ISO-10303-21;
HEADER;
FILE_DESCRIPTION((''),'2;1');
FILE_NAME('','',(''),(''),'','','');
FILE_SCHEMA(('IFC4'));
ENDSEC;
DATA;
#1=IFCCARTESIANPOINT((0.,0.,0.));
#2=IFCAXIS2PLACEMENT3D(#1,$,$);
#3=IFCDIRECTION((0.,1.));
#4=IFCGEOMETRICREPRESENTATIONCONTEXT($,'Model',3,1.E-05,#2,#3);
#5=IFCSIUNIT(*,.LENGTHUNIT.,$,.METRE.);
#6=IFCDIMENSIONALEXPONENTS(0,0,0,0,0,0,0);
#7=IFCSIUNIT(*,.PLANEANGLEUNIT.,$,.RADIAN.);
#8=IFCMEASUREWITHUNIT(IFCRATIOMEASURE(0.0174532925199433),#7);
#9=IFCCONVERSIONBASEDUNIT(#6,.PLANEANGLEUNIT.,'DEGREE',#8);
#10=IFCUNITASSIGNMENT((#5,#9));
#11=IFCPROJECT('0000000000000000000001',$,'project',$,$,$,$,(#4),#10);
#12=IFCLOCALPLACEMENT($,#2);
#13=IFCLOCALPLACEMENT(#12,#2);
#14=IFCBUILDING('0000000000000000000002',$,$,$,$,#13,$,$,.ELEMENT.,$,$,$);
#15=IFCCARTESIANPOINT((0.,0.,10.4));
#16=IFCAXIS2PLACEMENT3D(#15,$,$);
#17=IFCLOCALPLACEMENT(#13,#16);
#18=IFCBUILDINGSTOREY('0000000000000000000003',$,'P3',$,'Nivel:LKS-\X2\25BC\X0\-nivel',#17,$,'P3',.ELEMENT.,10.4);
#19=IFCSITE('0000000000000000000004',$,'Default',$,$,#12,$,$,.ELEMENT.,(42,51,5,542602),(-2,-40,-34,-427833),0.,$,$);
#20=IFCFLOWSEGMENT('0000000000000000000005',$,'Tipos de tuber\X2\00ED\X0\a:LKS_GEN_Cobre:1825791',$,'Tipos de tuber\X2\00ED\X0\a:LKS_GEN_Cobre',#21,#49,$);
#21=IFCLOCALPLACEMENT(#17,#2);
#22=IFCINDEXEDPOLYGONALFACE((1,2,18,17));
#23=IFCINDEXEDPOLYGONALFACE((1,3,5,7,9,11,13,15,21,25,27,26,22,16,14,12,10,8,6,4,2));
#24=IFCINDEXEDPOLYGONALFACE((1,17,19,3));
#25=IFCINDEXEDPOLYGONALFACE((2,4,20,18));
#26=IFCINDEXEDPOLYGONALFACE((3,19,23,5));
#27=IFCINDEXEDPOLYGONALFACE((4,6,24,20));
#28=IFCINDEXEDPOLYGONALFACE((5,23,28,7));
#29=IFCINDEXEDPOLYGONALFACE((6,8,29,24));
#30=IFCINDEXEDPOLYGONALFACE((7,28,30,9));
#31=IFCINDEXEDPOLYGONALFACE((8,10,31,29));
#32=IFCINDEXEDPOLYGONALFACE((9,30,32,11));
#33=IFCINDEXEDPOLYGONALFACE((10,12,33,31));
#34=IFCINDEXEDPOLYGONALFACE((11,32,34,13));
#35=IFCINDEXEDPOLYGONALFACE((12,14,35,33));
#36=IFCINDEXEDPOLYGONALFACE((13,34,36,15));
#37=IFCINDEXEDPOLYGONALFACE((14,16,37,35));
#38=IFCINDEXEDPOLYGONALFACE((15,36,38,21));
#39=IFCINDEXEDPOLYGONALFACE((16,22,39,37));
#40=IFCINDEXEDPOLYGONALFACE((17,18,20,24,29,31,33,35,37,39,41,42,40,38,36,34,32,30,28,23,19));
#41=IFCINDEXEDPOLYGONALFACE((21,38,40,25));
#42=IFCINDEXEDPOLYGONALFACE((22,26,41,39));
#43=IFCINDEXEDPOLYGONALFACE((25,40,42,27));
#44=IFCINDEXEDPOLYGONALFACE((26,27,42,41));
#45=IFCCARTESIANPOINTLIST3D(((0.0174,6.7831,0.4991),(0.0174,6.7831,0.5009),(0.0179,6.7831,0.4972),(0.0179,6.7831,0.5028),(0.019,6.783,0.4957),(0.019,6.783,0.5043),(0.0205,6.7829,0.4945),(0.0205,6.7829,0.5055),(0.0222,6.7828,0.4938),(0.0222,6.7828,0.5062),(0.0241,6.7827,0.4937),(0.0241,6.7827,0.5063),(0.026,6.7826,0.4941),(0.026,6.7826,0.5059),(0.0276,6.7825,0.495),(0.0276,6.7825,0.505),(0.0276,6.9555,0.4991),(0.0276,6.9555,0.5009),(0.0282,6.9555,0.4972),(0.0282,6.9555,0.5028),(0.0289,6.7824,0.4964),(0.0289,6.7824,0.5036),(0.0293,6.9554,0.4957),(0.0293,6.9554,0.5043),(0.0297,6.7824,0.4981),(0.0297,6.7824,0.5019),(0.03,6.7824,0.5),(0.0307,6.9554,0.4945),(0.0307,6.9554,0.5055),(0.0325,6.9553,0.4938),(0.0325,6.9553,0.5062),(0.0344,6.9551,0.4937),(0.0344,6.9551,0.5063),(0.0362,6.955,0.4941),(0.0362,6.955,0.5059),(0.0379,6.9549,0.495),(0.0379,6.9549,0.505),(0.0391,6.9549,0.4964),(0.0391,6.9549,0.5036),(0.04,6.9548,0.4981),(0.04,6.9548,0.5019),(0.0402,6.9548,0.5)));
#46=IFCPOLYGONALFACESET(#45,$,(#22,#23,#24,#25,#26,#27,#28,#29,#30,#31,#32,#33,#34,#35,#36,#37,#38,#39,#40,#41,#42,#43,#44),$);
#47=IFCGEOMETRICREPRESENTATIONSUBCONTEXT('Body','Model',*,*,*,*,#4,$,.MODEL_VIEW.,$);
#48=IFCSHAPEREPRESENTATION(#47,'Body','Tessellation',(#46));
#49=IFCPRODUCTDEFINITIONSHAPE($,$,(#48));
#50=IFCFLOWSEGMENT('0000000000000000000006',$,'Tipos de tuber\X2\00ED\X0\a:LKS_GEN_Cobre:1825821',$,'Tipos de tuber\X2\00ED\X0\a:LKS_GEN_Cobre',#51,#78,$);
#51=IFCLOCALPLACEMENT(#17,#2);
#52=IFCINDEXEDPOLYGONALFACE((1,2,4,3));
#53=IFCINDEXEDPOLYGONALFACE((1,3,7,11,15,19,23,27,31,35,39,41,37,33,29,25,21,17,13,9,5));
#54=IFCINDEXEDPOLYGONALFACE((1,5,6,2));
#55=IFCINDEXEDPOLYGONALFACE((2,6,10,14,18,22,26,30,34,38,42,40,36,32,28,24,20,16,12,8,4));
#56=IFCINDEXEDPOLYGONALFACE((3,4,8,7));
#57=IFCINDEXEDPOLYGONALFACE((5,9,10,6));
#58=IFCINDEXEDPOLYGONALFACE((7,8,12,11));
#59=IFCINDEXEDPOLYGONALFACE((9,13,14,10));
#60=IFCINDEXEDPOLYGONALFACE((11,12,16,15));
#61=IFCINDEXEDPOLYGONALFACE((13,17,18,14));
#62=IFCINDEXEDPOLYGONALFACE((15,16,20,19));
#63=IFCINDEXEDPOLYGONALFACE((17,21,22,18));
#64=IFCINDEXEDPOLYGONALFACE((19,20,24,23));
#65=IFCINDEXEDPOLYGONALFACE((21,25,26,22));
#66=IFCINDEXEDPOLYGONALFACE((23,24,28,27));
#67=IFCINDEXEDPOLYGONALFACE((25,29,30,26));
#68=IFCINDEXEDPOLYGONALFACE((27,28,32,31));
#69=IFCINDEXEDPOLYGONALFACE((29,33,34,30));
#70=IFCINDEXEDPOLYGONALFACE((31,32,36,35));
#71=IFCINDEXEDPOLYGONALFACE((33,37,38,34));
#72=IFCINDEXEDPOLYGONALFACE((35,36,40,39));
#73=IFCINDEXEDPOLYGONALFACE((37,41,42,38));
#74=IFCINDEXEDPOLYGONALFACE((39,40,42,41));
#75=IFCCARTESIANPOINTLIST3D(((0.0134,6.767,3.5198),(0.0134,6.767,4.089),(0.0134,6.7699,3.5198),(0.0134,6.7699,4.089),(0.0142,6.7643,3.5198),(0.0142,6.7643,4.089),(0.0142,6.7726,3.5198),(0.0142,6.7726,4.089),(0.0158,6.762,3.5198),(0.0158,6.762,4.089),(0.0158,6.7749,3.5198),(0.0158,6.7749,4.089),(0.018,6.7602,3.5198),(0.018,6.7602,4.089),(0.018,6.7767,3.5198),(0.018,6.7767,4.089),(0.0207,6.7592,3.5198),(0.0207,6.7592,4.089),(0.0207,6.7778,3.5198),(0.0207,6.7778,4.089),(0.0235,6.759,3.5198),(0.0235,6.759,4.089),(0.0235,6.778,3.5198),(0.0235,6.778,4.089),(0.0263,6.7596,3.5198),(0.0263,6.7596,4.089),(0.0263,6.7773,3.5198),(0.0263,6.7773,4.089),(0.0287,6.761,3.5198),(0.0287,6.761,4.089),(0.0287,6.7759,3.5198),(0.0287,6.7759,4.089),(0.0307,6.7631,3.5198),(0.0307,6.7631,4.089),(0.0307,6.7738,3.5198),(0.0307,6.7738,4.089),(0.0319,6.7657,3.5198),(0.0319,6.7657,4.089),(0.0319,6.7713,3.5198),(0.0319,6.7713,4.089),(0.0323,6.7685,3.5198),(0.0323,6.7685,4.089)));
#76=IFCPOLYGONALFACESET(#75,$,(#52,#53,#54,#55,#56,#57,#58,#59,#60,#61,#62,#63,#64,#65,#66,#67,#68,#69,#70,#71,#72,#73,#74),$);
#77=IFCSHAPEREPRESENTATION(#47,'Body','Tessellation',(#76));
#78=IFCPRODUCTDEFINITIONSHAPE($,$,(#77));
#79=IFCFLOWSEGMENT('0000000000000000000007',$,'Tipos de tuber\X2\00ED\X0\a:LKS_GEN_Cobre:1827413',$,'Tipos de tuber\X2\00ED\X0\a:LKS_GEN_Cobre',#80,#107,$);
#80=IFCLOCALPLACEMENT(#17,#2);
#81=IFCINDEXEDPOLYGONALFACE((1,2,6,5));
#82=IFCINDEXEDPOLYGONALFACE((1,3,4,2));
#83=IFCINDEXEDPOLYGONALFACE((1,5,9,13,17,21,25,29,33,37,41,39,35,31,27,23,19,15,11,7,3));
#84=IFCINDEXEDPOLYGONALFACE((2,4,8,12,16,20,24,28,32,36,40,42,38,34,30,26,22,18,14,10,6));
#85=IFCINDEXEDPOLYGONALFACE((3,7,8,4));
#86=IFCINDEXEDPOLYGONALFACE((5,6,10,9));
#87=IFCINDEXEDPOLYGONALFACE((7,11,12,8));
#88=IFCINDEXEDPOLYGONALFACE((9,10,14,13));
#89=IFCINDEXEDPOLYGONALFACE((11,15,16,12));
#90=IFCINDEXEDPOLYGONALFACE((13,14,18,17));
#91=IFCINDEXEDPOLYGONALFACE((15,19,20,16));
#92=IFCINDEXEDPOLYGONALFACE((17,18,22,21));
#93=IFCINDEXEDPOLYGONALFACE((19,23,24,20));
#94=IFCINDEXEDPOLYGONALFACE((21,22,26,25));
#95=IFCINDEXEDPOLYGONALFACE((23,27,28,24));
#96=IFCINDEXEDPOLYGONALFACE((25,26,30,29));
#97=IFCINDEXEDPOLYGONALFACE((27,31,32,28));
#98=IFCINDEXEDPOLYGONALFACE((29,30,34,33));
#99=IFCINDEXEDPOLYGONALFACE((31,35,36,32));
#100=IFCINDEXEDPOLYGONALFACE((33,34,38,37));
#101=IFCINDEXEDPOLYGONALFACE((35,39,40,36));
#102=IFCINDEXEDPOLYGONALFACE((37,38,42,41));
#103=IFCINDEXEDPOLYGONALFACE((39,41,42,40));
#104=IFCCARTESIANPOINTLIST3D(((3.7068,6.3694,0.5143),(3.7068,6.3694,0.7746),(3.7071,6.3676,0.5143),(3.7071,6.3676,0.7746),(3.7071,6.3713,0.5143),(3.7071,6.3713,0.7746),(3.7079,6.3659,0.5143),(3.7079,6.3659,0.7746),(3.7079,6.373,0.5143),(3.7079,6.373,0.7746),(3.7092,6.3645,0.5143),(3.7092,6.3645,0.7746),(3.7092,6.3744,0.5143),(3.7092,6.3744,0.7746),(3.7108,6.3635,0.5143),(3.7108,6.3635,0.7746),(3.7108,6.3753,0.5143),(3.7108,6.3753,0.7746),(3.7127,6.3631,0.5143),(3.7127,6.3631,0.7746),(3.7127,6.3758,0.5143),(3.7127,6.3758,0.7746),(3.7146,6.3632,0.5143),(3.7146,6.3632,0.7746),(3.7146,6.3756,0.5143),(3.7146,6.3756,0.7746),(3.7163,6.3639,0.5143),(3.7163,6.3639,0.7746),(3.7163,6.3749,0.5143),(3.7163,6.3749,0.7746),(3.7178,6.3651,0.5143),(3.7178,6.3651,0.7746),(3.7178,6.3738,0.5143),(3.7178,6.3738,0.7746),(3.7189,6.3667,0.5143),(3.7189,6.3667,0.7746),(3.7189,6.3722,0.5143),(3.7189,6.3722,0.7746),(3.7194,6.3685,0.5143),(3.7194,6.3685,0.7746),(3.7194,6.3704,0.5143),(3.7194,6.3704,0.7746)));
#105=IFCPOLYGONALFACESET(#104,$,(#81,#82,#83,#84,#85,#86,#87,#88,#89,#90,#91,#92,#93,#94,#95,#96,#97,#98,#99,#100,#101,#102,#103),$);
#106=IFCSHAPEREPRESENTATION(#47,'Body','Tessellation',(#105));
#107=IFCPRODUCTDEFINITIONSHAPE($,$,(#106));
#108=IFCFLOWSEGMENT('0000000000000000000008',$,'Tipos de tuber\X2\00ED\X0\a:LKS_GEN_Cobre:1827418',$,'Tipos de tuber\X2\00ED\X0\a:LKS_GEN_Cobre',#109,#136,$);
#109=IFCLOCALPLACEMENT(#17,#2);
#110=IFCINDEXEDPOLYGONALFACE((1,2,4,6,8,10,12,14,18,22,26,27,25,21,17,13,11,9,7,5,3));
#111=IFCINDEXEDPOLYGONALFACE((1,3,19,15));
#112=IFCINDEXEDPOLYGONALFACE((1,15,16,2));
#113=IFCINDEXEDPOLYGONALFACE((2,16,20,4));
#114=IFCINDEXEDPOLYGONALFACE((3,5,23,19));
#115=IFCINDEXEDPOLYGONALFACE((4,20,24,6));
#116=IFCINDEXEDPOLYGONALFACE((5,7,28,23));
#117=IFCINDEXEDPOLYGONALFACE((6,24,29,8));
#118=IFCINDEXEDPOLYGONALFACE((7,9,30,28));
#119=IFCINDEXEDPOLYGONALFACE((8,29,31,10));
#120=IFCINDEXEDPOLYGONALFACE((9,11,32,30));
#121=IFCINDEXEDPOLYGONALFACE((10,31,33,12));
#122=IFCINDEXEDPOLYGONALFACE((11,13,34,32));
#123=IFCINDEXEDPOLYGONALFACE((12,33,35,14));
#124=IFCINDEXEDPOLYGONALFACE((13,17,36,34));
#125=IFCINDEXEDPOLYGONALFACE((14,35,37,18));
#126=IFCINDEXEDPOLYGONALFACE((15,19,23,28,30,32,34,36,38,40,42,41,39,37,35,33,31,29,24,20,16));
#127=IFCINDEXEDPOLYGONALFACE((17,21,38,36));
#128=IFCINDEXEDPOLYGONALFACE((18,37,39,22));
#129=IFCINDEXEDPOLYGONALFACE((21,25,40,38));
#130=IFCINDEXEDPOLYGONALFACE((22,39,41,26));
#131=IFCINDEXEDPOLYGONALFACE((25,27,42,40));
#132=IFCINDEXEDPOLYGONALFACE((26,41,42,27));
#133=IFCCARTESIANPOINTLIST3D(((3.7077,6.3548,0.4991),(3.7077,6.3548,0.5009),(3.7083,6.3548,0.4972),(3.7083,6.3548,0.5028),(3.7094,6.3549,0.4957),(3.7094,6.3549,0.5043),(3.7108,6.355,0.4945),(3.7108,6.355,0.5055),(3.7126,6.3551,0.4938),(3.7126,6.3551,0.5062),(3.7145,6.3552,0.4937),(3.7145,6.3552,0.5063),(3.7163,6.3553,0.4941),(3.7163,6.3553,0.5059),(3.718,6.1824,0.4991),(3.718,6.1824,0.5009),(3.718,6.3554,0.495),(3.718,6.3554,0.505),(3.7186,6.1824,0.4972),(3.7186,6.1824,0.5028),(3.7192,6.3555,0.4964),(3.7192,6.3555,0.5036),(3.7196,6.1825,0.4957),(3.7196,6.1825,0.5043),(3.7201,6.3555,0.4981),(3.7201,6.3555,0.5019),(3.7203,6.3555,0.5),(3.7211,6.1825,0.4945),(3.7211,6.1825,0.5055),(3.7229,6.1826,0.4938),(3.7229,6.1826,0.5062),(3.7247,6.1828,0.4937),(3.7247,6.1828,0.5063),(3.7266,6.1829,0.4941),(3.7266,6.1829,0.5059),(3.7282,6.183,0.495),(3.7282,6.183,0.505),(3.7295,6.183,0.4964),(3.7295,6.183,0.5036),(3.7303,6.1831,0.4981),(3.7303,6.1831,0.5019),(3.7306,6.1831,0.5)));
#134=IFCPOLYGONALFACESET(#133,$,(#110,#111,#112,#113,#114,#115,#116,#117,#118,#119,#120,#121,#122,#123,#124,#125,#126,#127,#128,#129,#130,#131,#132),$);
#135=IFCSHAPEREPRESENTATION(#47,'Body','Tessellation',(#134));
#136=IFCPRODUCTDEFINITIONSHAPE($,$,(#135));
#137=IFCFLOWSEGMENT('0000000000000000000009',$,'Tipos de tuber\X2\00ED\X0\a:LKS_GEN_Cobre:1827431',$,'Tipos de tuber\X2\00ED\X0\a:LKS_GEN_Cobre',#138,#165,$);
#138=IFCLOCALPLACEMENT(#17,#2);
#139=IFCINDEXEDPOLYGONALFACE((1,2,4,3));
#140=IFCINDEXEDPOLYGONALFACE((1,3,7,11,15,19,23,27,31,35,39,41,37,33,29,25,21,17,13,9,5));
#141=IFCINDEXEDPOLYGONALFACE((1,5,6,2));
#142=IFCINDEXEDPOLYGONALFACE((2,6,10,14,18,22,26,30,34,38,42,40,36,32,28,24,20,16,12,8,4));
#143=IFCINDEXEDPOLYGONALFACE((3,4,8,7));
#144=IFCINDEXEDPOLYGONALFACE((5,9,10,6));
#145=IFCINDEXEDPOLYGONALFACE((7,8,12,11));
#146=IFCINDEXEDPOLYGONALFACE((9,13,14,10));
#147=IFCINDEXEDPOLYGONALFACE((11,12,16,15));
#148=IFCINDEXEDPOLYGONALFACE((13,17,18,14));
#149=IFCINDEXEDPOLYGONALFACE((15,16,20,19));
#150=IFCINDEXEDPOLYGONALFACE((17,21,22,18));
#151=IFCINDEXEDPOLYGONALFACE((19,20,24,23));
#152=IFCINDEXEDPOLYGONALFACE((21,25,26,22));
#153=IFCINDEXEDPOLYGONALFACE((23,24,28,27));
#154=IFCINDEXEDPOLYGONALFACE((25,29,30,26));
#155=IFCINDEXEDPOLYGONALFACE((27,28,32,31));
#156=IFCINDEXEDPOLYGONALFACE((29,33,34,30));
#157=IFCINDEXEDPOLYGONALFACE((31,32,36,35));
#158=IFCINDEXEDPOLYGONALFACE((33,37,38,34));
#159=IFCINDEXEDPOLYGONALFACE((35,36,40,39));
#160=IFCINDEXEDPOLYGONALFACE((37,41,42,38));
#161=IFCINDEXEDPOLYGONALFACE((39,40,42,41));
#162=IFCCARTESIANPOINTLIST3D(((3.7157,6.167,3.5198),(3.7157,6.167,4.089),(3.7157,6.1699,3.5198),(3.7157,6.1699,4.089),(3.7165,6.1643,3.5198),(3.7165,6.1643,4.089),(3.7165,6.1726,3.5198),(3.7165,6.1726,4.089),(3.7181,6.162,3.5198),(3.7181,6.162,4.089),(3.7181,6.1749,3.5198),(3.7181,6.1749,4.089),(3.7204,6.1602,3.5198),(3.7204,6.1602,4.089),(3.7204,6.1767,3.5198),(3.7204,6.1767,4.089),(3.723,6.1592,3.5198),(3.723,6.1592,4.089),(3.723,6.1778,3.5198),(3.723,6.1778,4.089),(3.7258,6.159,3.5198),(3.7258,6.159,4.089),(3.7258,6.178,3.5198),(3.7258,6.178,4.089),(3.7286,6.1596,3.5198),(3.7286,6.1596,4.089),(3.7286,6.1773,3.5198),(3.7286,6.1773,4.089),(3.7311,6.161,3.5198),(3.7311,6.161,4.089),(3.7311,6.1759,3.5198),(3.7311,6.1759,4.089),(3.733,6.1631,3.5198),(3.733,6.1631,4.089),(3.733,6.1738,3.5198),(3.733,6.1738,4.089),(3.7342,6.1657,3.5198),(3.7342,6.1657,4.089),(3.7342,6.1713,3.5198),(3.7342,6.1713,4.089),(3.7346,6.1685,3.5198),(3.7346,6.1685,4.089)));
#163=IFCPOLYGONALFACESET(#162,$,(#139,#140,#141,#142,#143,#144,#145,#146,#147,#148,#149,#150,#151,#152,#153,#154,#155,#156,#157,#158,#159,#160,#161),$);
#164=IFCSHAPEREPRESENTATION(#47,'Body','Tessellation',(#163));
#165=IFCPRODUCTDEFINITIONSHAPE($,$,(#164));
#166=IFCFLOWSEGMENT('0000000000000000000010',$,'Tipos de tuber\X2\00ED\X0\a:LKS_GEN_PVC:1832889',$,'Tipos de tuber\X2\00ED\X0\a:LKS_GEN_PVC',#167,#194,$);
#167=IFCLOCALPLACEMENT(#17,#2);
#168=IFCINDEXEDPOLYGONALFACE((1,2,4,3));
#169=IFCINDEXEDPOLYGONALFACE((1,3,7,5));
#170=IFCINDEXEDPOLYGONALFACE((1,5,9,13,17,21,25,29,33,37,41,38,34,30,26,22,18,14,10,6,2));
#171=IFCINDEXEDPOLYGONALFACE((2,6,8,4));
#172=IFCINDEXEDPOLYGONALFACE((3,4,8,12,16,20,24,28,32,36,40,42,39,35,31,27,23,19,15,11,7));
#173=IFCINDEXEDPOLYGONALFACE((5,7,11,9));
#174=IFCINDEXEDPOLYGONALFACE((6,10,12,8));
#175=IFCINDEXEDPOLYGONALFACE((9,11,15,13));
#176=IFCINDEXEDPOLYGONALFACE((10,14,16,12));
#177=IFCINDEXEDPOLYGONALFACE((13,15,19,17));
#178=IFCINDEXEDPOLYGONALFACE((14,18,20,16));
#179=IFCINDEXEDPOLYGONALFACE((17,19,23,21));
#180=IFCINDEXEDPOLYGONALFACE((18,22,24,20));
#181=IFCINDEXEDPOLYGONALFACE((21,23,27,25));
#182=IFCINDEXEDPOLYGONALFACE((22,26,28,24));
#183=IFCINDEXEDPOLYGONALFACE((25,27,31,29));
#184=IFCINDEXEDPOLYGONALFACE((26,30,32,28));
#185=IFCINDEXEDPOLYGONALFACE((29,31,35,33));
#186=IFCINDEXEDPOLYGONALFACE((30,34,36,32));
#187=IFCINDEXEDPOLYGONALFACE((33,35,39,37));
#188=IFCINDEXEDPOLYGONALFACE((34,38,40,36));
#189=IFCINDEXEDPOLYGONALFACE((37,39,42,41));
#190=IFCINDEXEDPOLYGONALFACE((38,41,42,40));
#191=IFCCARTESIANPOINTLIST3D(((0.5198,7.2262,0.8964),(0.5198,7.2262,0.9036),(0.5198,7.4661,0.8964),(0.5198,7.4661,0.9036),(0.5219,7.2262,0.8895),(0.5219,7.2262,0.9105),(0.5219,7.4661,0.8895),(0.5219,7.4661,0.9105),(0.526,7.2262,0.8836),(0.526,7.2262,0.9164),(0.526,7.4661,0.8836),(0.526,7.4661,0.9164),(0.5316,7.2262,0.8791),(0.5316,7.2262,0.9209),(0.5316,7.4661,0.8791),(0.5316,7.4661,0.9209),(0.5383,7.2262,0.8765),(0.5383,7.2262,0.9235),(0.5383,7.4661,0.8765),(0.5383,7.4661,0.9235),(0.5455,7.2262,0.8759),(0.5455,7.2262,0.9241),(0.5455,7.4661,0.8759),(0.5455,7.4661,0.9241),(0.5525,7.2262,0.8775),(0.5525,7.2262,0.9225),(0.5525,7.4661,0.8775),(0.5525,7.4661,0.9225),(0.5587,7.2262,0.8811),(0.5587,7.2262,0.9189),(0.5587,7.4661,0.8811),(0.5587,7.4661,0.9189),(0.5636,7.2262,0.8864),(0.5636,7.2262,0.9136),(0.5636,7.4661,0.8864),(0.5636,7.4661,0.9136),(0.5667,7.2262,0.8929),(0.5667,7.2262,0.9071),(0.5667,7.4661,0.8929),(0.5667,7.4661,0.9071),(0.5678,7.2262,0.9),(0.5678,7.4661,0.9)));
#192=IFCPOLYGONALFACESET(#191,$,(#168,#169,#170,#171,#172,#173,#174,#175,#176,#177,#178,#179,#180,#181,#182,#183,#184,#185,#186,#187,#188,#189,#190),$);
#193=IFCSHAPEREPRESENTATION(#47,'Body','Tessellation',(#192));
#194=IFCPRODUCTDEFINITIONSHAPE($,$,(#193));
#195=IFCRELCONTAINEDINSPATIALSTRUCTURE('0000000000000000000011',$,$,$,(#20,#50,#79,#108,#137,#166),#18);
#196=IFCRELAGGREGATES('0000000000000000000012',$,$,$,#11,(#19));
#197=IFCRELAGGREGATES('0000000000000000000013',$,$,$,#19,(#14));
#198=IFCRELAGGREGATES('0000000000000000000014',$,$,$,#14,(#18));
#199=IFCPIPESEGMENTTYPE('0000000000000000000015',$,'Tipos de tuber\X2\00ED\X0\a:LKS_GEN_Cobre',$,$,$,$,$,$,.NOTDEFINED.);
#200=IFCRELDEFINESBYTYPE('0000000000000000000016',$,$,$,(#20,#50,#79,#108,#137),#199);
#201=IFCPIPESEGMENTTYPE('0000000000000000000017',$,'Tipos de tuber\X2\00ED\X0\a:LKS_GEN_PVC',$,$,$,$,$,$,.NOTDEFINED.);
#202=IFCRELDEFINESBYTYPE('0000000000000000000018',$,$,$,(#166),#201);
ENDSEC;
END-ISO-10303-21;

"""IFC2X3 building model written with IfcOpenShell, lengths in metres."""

from ifc_helpers import new_model, entity, si_unit, converted_unit, direction, frame, frame_2d, origin, origin_2d_with_axis, place, context, subcontext, project, spatial, circle, extrude, type_object, element, save


model = new_model("IFC2X3")

# Units and contexts
model_context = context("Model", 3, precision=1e-05, world=origin(), true_north=direction((0.0, 1.0)))
body_context = subcontext(model_context, "Body", "Model", "MODEL_VIEW")
ifc_project = project(units=[si_unit("LENGTHUNIT", "METRE"), converted_unit("PLANEANGLEUNIT", "DEGREE", entity("IfcRatioMeasure", 0.0174532925199433), si_unit("PLANEANGLEUNIT", "RADIAN"), dimensions=[0, 0, 0, 0, 0, 0, 0])], contexts=[model_context])

# Site, building, storey
site_placement = place(None, origin())
site = spatial("IfcSite", under=ifc_project, at=site_placement, Name="Default", CompositionType="ELEMENT", RefLatitude=(42, 51, 5, 542602), RefLongitude=(-2, -40, -34, -427833), RefElevation=0.0)
building_placement = place(site_placement, origin())
building = spatial("IfcBuilding", under=site, at=building_placement, CompositionType="ELEMENT")
storey_placement = place(building_placement, frame((0.0, 0.0, 10.4)))
storey = spatial("IfcBuildingStorey", under=building, at=storey_placement, Name="P3", ObjectType="Nivel:LKS-▼-nivel", LongName="P3", CompositionType="ELEMENT", Elevation=10.4)

# Flow segments
pipe_segment_type_1 = type_object("IfcPipeSegmentType", Name="Tipos de tubería:LKS_GEN_Cobre", PredefinedType="NOTDEFINED")
flow_segment_1_placement = place(storey_placement, origin())
element("IfcFlowSegment", 1, at=flow_segment_1_placement, inside=storey, type_object=pipe_segment_type_1, Name="Tipos de tubería:LKS_GEN_Cobre:1825791", ObjectType="Tipos de tubería:LKS_GEN_Cobre", context=body_context, shape_type="SweptSolid", body=[
    extrude(circle(Radius=0.0063, at=frame_2d((0.0, 0.0), x_axis=(1.0, 0.0))), frame((0.0236, 6.7827, 0.5), z_axis=(0.059398, 0.998234, 0.0), x_axis=(0.998234, -0.059398, 0.0)), (0.0, 0.0, 1.0), 0.1727),
])
flow_segment_2_placement = place(storey_placement, origin())
element("IfcFlowSegment", 2, at=flow_segment_2_placement, inside=storey, type_object=pipe_segment_type_1, Name="Tipos de tubería:LKS_GEN_Cobre:1825821", ObjectType="Tipos de tubería:LKS_GEN_Cobre", context=body_context, shape_type="SweptSolid", body=[
    extrude(circle(Radius=0.0095, at=frame_2d((0.0, 0.0), x_axis=(1.0, 0.0))), frame((0.0228, 6.7685, 3.5198)), (0.0, 0.0, 1.0), 0.5692),
])
flow_segment_3_placement = place(storey_placement, origin())
element("IfcFlowSegment", 3, at=flow_segment_3_placement, inside=storey, type_object=pipe_segment_type_1, Name="Tipos de tubería:LKS_GEN_Cobre:1827413", ObjectType="Tipos de tubería:LKS_GEN_Cobre", context=body_context, shape_type="SweptSolid", body=[
    extrude(circle(Radius=0.0063, at=origin_2d_with_axis()), frame((3.7132, 6.3694, 0.5143), z_axis=(0.0, 0.0, 1.0), x_axis=(-1.0, 0.0, 0.0)), (0.0, 0.0, 1.0), 0.2603),
])
flow_segment_4_placement = place(storey_placement, origin())
element("IfcFlowSegment", 4, at=flow_segment_4_placement, inside=storey, type_object=pipe_segment_type_1, Name="Tipos de tubería:LKS_GEN_Cobre:1827418", ObjectType="Tipos de tubería:LKS_GEN_Cobre", context=body_context, shape_type="SweptSolid", body=[
    extrude(circle(Radius=0.0063, at=origin_2d_with_axis()), frame((3.714, 6.3552, 0.5), z_axis=(0.059398, -0.998234, 0.0), x_axis=(0.998234, 0.059398, 0.0)), (0.0, 0.0, 1.0), 0.1727),
])
flow_segment_5_placement = place(storey_placement, origin())
element("IfcFlowSegment", 5, at=flow_segment_5_placement, inside=storey, type_object=pipe_segment_type_1, Name="Tipos de tubería:LKS_GEN_Cobre:1827431", ObjectType="Tipos de tubería:LKS_GEN_Cobre", context=body_context, shape_type="SweptSolid", body=[
    extrude(circle(Radius=0.0095, at=origin_2d_with_axis()), frame((3.7251, 6.1685, 3.5198)), (0.0, 0.0, 1.0), 0.5692),
])
pipe_segment_type_2 = type_object("IfcPipeSegmentType", Name="Tipos de tubería:LKS_GEN_PVC", PredefinedType="NOTDEFINED")
flow_segment_6_placement = place(storey_placement, origin())
element("IfcFlowSegment", 6, at=flow_segment_6_placement, inside=storey, type_object=pipe_segment_type_2, Name="Tipos de tubería:LKS_GEN_PVC:1832889", ObjectType="Tipos de tubería:LKS_GEN_PVC", context=body_context, shape_type="SweptSolid", body=[
    extrude(circle(Radius=0.0241, at=frame_2d((0.0, 0.0), x_axis=(1.0, 0.0))), frame((0.5437, 7.2262, 0.9), z_axis=(0.0, 1.0, 0.0), x_axis=(1.0, 0.0, 0.0)), (0.0, 0.0, 1.0), 0.2398),
])

save(model, "model.ifc")
